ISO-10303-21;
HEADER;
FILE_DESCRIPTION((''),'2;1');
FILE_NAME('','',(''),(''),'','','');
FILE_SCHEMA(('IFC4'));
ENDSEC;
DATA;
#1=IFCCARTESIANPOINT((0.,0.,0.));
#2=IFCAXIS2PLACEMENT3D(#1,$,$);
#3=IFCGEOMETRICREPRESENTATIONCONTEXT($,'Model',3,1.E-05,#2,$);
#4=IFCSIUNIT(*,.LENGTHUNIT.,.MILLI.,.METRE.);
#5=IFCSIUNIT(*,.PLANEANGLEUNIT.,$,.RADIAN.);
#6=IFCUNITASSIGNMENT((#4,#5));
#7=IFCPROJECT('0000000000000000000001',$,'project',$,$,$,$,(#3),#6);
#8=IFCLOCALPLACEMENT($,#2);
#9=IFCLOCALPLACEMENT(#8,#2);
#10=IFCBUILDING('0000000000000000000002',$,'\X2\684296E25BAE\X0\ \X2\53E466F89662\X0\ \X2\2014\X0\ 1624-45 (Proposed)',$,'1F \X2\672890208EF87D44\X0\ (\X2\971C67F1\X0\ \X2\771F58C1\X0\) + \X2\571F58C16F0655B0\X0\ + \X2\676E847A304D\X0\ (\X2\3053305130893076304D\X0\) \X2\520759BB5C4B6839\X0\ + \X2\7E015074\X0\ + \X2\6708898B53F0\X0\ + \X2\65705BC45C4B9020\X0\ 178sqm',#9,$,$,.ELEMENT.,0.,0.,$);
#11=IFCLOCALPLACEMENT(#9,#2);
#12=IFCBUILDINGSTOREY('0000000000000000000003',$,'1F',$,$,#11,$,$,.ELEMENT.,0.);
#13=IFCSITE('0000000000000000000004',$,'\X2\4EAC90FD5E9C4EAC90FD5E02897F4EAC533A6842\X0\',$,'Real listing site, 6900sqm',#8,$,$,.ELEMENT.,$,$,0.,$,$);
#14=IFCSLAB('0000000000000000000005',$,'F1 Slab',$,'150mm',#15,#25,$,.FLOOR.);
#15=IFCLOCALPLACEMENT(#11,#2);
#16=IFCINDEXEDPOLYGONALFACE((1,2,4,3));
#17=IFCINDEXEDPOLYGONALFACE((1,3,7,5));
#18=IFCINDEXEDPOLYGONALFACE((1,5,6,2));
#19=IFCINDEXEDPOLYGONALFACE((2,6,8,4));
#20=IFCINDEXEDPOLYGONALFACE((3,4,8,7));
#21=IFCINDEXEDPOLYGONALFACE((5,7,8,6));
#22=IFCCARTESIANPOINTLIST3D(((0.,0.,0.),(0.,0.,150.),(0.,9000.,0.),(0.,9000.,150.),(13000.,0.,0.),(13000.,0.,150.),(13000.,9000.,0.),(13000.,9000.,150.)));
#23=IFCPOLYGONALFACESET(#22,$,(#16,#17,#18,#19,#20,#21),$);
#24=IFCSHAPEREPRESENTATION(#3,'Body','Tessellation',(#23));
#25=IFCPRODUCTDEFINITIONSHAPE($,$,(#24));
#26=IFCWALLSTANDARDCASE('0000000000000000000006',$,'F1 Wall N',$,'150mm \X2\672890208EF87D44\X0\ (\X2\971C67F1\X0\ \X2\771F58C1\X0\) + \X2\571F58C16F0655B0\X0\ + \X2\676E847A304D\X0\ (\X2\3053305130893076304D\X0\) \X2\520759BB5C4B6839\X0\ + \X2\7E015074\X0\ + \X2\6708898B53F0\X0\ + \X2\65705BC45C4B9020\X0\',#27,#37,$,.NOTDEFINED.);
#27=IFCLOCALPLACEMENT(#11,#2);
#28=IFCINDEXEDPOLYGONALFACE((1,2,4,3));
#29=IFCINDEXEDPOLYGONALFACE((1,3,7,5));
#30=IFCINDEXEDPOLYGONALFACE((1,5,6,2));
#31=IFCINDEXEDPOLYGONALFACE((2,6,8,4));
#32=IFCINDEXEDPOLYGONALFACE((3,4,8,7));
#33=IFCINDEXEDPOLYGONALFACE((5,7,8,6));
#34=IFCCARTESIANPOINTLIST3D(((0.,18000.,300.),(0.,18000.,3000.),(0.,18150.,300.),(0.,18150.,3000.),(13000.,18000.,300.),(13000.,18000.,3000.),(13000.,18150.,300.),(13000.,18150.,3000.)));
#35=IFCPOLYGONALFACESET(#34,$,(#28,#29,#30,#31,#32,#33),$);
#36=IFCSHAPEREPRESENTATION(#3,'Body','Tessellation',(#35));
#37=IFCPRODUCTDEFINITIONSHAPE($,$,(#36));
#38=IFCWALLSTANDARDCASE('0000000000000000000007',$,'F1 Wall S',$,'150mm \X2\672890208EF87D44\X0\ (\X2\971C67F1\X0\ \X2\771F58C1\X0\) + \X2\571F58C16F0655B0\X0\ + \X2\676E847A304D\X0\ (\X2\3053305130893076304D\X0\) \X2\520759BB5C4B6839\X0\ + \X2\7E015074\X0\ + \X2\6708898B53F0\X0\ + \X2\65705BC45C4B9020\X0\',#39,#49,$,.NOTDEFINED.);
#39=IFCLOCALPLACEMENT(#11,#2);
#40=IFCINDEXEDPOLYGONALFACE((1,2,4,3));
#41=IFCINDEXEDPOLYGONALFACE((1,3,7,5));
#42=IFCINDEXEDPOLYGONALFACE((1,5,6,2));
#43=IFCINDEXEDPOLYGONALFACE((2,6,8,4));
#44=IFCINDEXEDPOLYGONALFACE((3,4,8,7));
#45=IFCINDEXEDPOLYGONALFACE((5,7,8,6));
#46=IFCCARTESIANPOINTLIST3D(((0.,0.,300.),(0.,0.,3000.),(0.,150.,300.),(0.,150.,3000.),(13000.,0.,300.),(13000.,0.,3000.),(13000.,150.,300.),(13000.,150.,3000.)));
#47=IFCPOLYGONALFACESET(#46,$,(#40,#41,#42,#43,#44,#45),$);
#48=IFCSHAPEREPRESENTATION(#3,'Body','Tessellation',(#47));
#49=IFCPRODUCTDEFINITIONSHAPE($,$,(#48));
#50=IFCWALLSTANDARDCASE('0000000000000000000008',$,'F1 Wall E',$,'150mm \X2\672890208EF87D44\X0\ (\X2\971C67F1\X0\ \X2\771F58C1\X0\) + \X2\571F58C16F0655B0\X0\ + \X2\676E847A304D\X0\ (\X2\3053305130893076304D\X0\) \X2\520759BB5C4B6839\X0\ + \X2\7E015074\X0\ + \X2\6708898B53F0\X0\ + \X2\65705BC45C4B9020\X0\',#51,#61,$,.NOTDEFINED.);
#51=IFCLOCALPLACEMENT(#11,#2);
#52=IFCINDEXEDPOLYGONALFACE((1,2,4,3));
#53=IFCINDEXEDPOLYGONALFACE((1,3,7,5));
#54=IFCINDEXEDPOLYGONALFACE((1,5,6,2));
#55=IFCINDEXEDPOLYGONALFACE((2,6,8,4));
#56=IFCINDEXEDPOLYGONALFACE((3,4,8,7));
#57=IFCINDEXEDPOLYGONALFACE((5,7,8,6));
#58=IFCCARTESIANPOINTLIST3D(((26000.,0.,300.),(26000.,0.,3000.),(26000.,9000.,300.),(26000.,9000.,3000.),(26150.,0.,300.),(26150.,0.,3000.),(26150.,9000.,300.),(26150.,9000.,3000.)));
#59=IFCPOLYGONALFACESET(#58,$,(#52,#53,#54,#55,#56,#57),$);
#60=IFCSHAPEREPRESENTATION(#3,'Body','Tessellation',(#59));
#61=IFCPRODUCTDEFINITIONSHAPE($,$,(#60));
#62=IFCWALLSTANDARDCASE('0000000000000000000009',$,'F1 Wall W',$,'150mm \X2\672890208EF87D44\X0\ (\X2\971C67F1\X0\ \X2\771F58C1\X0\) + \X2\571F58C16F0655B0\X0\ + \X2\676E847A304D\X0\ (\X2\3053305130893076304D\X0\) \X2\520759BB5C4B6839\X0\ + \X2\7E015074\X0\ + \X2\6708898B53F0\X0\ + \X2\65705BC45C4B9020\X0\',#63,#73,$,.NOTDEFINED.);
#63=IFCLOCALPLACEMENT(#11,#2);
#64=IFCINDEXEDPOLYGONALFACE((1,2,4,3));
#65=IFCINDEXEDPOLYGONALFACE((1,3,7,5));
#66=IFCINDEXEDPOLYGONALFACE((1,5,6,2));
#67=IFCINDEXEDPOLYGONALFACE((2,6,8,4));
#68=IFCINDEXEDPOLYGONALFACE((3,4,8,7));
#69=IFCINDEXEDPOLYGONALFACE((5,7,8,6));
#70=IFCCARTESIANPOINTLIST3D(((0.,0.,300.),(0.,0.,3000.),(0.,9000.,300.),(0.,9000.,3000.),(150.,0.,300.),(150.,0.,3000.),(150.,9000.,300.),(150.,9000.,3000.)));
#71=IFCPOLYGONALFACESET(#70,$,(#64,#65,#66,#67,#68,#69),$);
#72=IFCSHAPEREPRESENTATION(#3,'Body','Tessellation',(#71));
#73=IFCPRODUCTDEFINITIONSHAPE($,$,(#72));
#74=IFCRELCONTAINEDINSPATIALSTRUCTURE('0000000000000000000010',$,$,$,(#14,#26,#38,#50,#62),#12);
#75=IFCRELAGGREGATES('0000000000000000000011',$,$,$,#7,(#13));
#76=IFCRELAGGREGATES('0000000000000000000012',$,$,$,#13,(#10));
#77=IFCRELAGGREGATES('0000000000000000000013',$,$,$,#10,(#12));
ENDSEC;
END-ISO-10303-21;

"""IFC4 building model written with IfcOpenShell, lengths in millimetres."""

from ifc_helpers import new_model, si_unit, frame, frame_2d, origin, place, context, project, spatial, rectangle, extrude, element, save


model = new_model("IFC4")

# Units and contexts
model_context = context("Model", 3, precision=1e-05, world=origin())
ifc_project = project(units=[si_unit("LENGTHUNIT", "METRE", prefix="MILLI"), si_unit("PLANEANGLEUNIT", "RADIAN")], contexts=[model_context])

# Site, building, storey
site_placement = place(None, origin())
site = spatial("IfcSite", under=ifc_project, at=site_placement, Name="京都府京都市西京区桂", ObjectType="Real listing site, 6900sqm", CompositionType="ELEMENT", RefElevation=0.0)
building_placement = place(site_placement, origin())
building = spatial("IfcBuilding", under=site, at=building_placement, Name="桂離宮 古書院 — 1624-45 (Proposed)", ObjectType="1F 木造軸組 (霜柱 真壁) + 土壁漆喰 + 杮葺き (こけらぶき) 切妻屋根 + 縁側 + 月見台 + 数寄屋造 178sqm", CompositionType="ELEMENT", ElevationOfRefHeight=0.0, ElevationOfTerrain=0.0)
storey_placement = place(building_placement, origin())
storey = spatial("IfcBuildingStorey", under=building, at=storey_placement, Name="1F", CompositionType="ELEMENT", Elevation=0.0)

# Slab
slab_placement = place(storey_placement, origin())
element("IfcSlab", 1, at=slab_placement, inside=storey, Name="F1 Slab", ObjectType="150mm", PredefinedType="FLOOR", context=model_context, shape_type="SweptSolid", body=[
    extrude(rectangle(XDim=13000.0, YDim=9000.0, at=frame_2d((6500.0, 4500.0))), origin(), (0.0, 0.0, 1.0), 150.0),
])

# Walls
wall_1_placement = place(storey_placement, frame((0.0, 9000.0, 150.0)))
element("IfcWallStandardCase", 2, at=wall_1_placement, inside=storey, Name="F1 Wall N", ObjectType="150mm 木造軸組 (霜柱 真壁) + 土壁漆喰 + 杮葺き (こけらぶき) 切妻屋根 + 縁側 + 月見台 + 数寄屋造", PredefinedType="NOTDEFINED", context=model_context, shape_type="SweptSolid", body=[
    extrude(rectangle(XDim=13000.0, YDim=150.0, at=frame_2d((6500.0, 75.0))), frame((0.0, 9000.0, 150.0)), (0.0, 0.0, 1.0), 2700.0),
])
wall_2_placement = place(storey_placement, frame((0.0, 0.0, 150.0)))
element("IfcWallStandardCase", 3, at=wall_2_placement, inside=storey, Name="F1 Wall S", ObjectType="150mm 木造軸組 (霜柱 真壁) + 土壁漆喰 + 杮葺き (こけらぶき) 切妻屋根 + 縁側 + 月見台 + 数寄屋造", PredefinedType="NOTDEFINED", context=model_context, shape_type="SweptSolid", body=[
    extrude(rectangle(XDim=13000.0, YDim=150.0, at=frame_2d((6500.0, 75.0))), frame((0.0, 0.0, 150.0)), (0.0, 0.0, 1.0), 2700.0),
])
wall_3_placement = place(storey_placement, frame((13000.0, 0.0, 150.0)))
element("IfcWallStandardCase", 4, at=wall_3_placement, inside=storey, Name="F1 Wall E", ObjectType="150mm 木造軸組 (霜柱 真壁) + 土壁漆喰 + 杮葺き (こけらぶき) 切妻屋根 + 縁側 + 月見台 + 数寄屋造", PredefinedType="NOTDEFINED", context=model_context, shape_type="SweptSolid", body=[
    extrude(rectangle(XDim=150.0, YDim=9000.0, at=frame_2d((75.0, 4500.0))), frame((13000.0, 0.0, 150.0)), (0.0, 0.0, 1.0), 2700.0),
])
wall_4_placement = place(storey_placement, frame((0.0, 0.0, 150.0)))
element("IfcWallStandardCase", 5, at=wall_4_placement, inside=storey, Name="F1 Wall W", ObjectType="150mm 木造軸組 (霜柱 真壁) + 土壁漆喰 + 杮葺き (こけらぶき) 切妻屋根 + 縁側 + 月見台 + 数寄屋造", PredefinedType="NOTDEFINED", context=model_context, shape_type="SweptSolid", body=[
    extrude(rectangle(XDim=150.0, YDim=9000.0, at=frame_2d((75.0, 4500.0))), frame((0.0, 0.0, 150.0)), (0.0, 0.0, 1.0), 2700.0),
])

save(model, "model.ifc")
